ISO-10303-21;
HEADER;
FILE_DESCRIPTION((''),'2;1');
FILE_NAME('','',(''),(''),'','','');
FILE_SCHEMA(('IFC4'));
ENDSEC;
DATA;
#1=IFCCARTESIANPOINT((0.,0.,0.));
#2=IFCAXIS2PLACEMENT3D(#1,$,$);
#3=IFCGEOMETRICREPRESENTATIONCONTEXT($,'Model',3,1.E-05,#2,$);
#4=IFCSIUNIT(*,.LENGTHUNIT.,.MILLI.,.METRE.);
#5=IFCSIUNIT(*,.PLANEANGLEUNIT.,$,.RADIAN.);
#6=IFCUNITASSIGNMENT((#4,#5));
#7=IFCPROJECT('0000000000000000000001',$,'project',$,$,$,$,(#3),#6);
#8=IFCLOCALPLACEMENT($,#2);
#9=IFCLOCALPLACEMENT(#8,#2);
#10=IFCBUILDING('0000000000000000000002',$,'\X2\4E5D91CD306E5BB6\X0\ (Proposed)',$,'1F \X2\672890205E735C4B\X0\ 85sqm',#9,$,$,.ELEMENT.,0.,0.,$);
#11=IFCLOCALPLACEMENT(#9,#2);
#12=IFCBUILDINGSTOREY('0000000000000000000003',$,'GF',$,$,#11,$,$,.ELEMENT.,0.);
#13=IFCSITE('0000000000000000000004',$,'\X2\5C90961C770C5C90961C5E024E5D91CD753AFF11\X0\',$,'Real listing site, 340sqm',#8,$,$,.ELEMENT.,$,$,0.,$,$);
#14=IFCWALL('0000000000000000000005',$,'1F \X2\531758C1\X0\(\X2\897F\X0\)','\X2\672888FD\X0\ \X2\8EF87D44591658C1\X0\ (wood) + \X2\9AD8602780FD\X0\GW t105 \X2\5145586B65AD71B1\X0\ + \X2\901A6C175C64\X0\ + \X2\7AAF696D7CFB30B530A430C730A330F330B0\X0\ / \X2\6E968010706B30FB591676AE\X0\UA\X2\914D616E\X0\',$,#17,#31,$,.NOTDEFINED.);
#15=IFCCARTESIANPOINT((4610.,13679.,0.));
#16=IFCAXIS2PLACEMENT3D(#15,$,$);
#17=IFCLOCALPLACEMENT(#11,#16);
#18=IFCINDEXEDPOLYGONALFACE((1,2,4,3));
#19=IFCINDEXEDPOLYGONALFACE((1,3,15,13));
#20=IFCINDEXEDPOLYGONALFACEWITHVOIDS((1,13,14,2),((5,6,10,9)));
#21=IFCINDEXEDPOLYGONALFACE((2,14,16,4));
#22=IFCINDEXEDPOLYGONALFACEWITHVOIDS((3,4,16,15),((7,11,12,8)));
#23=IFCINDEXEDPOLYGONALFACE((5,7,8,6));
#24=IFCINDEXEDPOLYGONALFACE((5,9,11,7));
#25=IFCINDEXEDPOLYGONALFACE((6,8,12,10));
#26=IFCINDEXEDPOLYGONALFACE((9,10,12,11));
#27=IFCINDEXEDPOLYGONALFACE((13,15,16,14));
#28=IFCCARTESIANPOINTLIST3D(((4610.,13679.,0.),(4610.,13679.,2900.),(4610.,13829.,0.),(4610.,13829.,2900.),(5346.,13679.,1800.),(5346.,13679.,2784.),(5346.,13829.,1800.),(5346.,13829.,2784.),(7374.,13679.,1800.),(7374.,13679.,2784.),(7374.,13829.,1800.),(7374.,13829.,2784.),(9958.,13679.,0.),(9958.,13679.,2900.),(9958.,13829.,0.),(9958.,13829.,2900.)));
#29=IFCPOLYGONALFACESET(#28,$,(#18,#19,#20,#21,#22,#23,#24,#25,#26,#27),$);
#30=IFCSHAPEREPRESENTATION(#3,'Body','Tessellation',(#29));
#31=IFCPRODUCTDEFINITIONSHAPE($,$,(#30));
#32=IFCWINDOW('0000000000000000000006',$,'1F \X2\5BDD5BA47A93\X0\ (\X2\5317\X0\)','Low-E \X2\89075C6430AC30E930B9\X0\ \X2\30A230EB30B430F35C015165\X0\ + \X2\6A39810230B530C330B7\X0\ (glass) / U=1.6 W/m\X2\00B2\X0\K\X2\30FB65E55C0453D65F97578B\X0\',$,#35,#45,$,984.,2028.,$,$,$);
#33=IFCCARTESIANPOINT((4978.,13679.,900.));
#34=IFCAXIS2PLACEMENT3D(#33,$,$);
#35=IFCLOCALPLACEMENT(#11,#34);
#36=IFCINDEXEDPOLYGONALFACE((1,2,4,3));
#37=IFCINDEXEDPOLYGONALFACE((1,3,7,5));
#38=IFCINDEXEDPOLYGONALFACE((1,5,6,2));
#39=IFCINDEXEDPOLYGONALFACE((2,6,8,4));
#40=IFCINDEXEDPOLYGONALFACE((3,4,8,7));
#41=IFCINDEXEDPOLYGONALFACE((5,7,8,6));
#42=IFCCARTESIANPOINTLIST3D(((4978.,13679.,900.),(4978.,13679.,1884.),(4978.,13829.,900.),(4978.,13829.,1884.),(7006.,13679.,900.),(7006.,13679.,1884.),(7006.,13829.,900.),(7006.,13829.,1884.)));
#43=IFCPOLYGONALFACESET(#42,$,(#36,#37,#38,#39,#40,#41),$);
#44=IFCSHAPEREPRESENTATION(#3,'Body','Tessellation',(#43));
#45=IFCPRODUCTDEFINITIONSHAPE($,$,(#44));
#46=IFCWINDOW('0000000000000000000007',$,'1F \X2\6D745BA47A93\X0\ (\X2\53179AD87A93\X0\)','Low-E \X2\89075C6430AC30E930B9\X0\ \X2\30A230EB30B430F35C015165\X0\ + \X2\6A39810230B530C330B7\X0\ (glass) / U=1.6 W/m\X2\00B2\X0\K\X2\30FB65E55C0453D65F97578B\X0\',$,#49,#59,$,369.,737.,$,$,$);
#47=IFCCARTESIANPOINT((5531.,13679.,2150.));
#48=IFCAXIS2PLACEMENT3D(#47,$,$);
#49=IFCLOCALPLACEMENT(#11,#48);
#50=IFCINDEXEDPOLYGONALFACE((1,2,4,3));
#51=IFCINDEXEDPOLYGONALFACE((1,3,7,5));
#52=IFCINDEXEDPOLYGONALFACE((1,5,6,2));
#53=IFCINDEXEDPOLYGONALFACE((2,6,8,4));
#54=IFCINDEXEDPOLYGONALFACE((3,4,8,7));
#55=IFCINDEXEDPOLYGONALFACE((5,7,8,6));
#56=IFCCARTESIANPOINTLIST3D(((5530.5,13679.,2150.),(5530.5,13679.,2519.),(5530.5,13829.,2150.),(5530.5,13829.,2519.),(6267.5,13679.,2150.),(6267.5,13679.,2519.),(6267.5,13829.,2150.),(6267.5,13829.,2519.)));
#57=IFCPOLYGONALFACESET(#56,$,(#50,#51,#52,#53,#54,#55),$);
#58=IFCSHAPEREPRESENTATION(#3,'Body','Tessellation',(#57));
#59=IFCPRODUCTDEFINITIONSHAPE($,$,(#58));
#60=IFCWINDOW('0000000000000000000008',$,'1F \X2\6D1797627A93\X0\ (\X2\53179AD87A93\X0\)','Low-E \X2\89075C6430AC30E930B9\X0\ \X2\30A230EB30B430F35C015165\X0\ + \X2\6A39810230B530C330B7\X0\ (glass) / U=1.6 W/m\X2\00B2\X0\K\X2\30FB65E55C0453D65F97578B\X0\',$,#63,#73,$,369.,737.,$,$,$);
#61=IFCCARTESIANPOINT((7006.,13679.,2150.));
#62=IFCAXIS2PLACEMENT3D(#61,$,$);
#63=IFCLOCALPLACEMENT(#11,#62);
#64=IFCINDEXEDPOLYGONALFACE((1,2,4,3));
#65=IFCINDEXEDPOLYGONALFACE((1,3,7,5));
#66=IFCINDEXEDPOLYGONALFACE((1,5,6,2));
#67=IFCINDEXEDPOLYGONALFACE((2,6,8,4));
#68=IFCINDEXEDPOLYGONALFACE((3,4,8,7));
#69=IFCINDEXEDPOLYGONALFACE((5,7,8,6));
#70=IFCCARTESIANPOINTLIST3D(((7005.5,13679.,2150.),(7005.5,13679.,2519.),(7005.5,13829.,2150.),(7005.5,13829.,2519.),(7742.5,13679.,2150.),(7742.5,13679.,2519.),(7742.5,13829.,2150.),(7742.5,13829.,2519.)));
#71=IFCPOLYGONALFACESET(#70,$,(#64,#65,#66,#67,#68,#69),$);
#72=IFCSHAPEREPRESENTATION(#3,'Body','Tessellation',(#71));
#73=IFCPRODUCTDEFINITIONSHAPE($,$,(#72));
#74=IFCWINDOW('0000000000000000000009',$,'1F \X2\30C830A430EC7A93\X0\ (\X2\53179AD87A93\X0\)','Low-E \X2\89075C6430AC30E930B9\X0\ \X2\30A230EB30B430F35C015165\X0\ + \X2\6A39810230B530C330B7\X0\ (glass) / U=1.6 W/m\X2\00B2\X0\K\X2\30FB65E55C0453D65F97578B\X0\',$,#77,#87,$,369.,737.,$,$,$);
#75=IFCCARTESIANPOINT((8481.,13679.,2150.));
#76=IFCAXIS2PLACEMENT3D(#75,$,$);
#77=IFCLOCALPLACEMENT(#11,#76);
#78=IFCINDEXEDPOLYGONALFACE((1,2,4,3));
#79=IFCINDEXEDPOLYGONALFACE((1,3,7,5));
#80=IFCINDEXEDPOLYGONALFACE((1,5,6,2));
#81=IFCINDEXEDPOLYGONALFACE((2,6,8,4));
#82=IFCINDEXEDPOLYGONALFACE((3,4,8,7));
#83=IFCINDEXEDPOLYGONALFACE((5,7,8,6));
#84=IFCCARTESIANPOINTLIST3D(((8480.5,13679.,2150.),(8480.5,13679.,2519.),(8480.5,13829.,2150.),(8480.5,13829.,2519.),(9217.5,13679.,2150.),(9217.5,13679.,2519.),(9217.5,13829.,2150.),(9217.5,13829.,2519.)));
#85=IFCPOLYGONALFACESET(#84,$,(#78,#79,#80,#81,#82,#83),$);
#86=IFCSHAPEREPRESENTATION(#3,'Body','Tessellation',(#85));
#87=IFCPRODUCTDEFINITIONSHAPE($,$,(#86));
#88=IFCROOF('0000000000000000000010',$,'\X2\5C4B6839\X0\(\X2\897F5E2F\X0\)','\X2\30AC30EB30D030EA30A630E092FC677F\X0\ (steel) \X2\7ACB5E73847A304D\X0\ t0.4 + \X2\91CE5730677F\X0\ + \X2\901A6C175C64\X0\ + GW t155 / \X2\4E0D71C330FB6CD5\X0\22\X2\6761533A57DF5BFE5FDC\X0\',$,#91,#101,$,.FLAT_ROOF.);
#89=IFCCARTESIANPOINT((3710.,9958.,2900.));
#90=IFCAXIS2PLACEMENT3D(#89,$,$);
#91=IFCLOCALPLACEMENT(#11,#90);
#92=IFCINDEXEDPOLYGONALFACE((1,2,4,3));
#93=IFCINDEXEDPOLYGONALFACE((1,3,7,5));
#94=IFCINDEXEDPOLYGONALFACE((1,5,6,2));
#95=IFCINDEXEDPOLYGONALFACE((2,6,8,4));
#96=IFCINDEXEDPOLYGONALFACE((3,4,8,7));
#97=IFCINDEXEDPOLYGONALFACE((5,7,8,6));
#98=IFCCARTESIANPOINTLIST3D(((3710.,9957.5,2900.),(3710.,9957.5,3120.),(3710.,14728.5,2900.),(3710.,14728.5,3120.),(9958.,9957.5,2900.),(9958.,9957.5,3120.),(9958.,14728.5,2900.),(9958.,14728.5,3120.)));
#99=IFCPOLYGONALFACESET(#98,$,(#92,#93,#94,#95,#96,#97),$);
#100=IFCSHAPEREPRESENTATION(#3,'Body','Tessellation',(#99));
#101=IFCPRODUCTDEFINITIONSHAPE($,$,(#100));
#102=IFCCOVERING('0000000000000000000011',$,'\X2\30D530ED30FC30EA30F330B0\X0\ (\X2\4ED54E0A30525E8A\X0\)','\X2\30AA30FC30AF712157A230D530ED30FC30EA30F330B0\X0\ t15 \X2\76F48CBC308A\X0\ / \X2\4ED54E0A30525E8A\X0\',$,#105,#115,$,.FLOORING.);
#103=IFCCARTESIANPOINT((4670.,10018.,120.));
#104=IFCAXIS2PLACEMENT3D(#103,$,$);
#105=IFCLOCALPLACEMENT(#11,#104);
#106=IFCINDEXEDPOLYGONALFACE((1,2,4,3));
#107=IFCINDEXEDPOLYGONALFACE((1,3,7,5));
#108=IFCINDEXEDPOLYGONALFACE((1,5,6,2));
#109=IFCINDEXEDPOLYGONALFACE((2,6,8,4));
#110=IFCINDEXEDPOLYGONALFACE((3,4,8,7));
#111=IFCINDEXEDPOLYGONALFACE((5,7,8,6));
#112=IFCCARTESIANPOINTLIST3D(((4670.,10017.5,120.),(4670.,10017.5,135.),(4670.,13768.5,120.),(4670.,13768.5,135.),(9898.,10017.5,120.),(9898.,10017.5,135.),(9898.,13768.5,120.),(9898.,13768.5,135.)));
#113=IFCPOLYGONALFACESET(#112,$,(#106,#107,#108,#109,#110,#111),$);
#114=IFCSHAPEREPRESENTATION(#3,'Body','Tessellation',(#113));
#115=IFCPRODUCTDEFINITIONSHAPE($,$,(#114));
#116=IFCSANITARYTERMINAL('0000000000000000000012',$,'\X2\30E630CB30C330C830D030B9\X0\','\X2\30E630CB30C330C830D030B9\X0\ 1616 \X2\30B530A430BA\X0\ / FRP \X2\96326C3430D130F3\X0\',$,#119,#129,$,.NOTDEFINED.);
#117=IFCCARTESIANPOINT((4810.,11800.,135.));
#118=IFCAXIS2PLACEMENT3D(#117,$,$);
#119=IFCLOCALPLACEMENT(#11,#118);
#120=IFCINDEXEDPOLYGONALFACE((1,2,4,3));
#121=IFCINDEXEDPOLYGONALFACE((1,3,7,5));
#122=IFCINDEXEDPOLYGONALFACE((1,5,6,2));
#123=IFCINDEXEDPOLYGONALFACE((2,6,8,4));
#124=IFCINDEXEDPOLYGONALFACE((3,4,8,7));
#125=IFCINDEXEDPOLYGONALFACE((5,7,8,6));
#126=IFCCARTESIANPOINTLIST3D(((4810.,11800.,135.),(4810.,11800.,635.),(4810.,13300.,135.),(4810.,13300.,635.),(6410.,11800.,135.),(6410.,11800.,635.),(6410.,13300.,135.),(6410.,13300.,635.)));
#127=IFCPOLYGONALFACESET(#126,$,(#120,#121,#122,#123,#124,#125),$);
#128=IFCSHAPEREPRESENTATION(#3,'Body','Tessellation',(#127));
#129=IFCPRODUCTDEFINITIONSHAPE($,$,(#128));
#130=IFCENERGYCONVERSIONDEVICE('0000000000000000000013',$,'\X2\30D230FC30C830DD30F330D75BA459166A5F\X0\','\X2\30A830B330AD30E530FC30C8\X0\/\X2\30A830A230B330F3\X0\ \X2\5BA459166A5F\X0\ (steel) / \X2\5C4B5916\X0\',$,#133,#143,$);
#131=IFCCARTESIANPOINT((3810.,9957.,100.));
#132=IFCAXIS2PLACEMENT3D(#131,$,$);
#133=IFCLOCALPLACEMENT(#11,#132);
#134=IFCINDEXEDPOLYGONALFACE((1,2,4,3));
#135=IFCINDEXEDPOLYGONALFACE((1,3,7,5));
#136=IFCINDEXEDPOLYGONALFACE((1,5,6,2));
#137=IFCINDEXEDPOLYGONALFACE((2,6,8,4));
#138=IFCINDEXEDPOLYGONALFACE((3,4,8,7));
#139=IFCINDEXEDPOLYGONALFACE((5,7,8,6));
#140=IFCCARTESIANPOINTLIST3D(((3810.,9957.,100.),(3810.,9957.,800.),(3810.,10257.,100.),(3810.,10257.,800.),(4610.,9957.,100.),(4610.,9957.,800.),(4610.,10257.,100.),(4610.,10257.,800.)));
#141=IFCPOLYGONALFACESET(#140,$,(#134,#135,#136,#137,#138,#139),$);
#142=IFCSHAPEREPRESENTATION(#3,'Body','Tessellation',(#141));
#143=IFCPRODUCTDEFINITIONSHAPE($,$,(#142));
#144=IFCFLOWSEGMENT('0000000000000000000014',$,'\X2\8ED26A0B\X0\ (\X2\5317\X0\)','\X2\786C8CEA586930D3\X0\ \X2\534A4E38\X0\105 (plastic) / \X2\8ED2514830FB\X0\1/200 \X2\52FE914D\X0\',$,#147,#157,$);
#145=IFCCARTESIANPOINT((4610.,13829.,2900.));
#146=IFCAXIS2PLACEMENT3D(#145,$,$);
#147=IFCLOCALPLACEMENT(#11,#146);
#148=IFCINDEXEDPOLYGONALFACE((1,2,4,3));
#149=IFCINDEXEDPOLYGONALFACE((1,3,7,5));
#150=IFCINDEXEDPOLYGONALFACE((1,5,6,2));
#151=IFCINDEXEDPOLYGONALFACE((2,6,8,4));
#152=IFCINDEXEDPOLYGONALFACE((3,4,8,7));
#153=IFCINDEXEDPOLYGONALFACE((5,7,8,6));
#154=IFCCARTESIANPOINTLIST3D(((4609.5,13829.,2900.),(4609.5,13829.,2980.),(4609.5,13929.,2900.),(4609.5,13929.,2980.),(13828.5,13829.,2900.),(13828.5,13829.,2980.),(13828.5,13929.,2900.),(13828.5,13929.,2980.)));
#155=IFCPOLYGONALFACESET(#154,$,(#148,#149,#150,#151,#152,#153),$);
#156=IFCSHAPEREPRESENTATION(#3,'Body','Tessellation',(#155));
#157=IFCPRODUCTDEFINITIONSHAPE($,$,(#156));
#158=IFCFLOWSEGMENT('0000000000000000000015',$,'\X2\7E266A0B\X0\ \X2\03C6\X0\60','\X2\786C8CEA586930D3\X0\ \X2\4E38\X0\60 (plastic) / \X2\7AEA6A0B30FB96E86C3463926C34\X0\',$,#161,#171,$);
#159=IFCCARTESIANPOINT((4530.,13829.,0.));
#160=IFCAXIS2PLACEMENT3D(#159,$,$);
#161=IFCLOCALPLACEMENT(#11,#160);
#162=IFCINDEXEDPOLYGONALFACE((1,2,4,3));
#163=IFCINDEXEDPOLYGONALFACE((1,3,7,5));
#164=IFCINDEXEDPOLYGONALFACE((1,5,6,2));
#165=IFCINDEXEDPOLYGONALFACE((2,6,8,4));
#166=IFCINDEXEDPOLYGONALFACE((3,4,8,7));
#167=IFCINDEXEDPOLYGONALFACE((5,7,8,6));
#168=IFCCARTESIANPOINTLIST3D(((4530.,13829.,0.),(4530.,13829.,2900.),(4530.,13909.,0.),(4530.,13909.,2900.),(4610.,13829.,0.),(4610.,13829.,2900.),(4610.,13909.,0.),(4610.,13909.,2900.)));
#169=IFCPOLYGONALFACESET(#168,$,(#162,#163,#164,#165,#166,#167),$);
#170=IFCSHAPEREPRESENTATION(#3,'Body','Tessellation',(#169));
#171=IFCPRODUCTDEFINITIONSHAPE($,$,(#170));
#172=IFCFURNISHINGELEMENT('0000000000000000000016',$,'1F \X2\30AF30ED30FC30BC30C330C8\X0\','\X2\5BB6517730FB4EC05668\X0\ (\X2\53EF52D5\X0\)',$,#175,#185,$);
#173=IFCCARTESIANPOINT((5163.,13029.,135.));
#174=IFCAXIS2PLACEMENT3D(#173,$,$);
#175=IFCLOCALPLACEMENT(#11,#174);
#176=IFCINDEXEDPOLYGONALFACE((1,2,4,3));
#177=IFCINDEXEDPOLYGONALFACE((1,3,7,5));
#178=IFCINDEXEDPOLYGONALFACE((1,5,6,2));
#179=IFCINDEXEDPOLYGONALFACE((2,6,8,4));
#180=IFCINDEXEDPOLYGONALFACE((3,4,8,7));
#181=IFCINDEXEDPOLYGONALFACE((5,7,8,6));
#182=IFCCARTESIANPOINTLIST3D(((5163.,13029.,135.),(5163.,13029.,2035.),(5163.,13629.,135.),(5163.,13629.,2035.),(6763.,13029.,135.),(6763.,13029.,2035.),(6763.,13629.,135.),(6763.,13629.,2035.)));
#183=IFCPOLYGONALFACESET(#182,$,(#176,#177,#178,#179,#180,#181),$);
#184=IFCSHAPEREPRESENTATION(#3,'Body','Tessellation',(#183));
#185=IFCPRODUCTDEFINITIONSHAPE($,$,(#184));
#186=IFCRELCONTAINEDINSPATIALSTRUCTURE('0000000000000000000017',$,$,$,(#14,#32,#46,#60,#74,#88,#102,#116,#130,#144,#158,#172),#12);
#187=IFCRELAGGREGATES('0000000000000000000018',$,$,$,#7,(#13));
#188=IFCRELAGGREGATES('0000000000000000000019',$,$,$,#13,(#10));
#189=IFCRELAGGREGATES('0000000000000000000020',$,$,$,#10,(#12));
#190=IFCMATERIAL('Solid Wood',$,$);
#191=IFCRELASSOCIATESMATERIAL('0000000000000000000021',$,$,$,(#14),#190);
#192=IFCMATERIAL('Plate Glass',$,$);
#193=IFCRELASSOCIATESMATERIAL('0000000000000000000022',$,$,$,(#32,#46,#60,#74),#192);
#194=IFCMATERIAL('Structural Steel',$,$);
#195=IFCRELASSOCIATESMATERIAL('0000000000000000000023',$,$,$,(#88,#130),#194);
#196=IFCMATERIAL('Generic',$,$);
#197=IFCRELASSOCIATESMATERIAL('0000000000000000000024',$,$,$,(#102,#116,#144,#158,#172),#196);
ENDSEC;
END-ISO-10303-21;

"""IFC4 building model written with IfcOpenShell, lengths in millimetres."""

from ifc_helpers import new_model, si_unit, frame, frame_2d, origin, place, context, project, spatial, rectangle, extrude, material, element, fill, save


model = new_model("IFC4")

# Units and contexts
model_context = context("Model", 3, precision=1e-05, world=origin())
ifc_project = project(units=[si_unit("LENGTHUNIT", "METRE", prefix="MILLI"), si_unit("PLANEANGLEUNIT", "RADIAN")], contexts=[model_context])

# Site, building, storey
site_placement = place(None, origin())
site = spatial("IfcSite", under=ifc_project, at=site_placement, Name="岐阜県岐阜市九重町１", ObjectType="Real listing site, 340sqm", CompositionType="ELEMENT", RefElevation=0.0)
building_placement = place(site_placement, origin())
building = spatial("IfcBuilding", under=site, at=building_placement, Name="九重の家 (Proposed)", ObjectType="1F 木造平屋 85sqm", CompositionType="ELEMENT", ElevationOfRefHeight=0.0, ElevationOfTerrain=0.0)
storey_placement = place(building_placement, origin())
storey = spatial("IfcBuildingStorey", under=building, at=storey_placement, Name="GF", CompositionType="ELEMENT", Elevation=0.0)

# Shared definitions
ifc_material_1 = material(Name="Solid Wood")

# Wall, openings, windows
wall_1_placement = place(storey_placement, frame((4610.0, 13679.0, 0.0)))
wall_1 = element("IfcWall", 1, at=wall_1_placement, inside=storey, material=ifc_material_1, Name="1F 北壁(西)", Description="木製 軸組外壁 (wood) + 高性能GW t105 充填断熱 + 通気層 + 窯業系サイディング / 準耐火・外皮UA配慮", PredefinedType="NOTDEFINED", context=model_context, shape_type="SweptSolid", body=[
    extrude(rectangle(XDim=5348.0, YDim=150.0, at=frame_2d((2674.0, 75.0))), frame((4610.0, 13679.0, 0.0)), (0.0, 0.0, 1.0), 2900.0),
])
opening_1_placement = place(storey_placement, frame((4978.0, 13679.0, 900.0)))
opening_1 = element("IfcOpeningElement", 2, at=opening_1_placement, cuts=wall_1, PredefinedType="NOTDEFINED", context=model_context, shape_type="SweptSolid", body=[
    extrude(rectangle(XDim=2028.0, YDim=150.0, at=frame_2d((1014.0, 75.0))), frame((4978.0, 13679.0, 900.0)), (0.0, 0.0, 1.0), 984.0),
])
opening_2_placement = place(storey_placement, frame((5531.0, 13679.0, 2150.0)))
opening_2 = element("IfcOpeningElement", 3, at=opening_2_placement, cuts=wall_1, PredefinedType="NOTDEFINED", context=model_context, shape_type="SweptSolid", body=[
    extrude(rectangle(XDim=737.0, YDim=150.0, at=frame_2d((368.0, 75.0))), frame((5531.0, 13679.0, 2150.0)), (0.0, 0.0, 1.0), 369.0),
])
opening_3_placement = place(storey_placement, frame((7006.0, 13679.0, 2150.0)))
opening_3 = element("IfcOpeningElement", 4, at=opening_3_placement, cuts=wall_1, PredefinedType="NOTDEFINED", context=model_context, shape_type="SweptSolid", body=[
    extrude(rectangle(XDim=737.0, YDim=150.0, at=frame_2d((368.0, 75.0))), frame((7006.0, 13679.0, 2150.0)), (0.0, 0.0, 1.0), 369.0),
])
opening_4_placement = place(storey_placement, frame((8481.0, 13679.0, 2150.0)))
opening_4 = element("IfcOpeningElement", 5, at=opening_4_placement, cuts=wall_1, PredefinedType="NOTDEFINED", context=model_context, shape_type="SweptSolid", body=[
    extrude(rectangle(XDim=737.0, YDim=150.0, at=frame_2d((368.0, 75.0))), frame((8481.0, 13679.0, 2150.0)), (0.0, 0.0, 1.0), 369.0),
])
ifc_material_2 = material(Name="Plate Glass")
window_1_placement = place(storey_placement, frame((4978.0, 13679.0, 900.0)))
window_1 = element("IfcWindow", 6, at=window_1_placement, inside=storey, material=ifc_material_2, Name="1F 寝室窓 (北)", Description="Low-E 複層ガラス アルゴン封入 + 樹脂サッシ (glass) / U=1.6 W/m²K・日射取得型", OverallHeight=984.0, OverallWidth=2028.0, context=model_context, shape_type="SweptSolid", body=[
    extrude(rectangle(XDim=2028.0, YDim=150.0, at=frame_2d((1014.0, 75.0))), frame((4978.0, 13679.0, 900.0)), (0.0, 0.0, 1.0), 984.0),
])
fill(opening_1, window_1)
window_2_placement = place(storey_placement, frame((5531.0, 13679.0, 2150.0)))
window_2 = element("IfcWindow", 7, at=window_2_placement, inside=storey, material=ifc_material_2, Name="1F 浴室窓 (北高窓)", Description="Low-E 複層ガラス アルゴン封入 + 樹脂サッシ (glass) / U=1.6 W/m²K・日射取得型", OverallHeight=369.0, OverallWidth=737.0, context=model_context, shape_type="SweptSolid", body=[
    extrude(rectangle(XDim=737.0, YDim=150.0, at=frame_2d((368.0, 75.0))), frame((5531.0, 13679.0, 2150.0)), (0.0, 0.0, 1.0), 369.0),
])
fill(opening_2, window_2)
window_3_placement = place(storey_placement, frame((7006.0, 13679.0, 2150.0)))
window_3 = element("IfcWindow", 8, at=window_3_placement, inside=storey, material=ifc_material_2, Name="1F 洗面窓 (北高窓)", Description="Low-E 複層ガラス アルゴン封入 + 樹脂サッシ (glass) / U=1.6 W/m²K・日射取得型", OverallHeight=369.0, OverallWidth=737.0, context=model_context, shape_type="SweptSolid", body=[
    extrude(rectangle(XDim=737.0, YDim=150.0, at=frame_2d((368.0, 75.0))), frame((7006.0, 13679.0, 2150.0)), (0.0, 0.0, 1.0), 369.0),
])
fill(opening_3, window_3)
window_4_placement = place(storey_placement, frame((8481.0, 13679.0, 2150.0)))
window_4 = element("IfcWindow", 9, at=window_4_placement, inside=storey, material=ifc_material_2, Name="1F トイレ窓 (北高窓)", Description="Low-E 複層ガラス アルゴン封入 + 樹脂サッシ (glass) / U=1.6 W/m²K・日射取得型", OverallHeight=369.0, OverallWidth=737.0, context=model_context, shape_type="SweptSolid", body=[
    extrude(rectangle(XDim=737.0, YDim=150.0, at=frame_2d((368.0, 75.0))), frame((8481.0, 13679.0, 2150.0)), (0.0, 0.0, 1.0), 369.0),
])
fill(opening_4, window_4)

# Roof
ifc_material_3 = material(Name="Structural Steel")
roof_placement = place(storey_placement, frame((3710.0, 9958.0, 2900.0)))
element("IfcRoof", 10, at=roof_placement, inside=storey, material=ifc_material_3, Name="屋根(西帯)", Description="ガルバリウム鋼板 (steel) 立平葺き t0.4 + 野地板 + 通気層 + GW t155 / 不燃・法22条区域対応", PredefinedType="FLAT_ROOF", context=model_context, shape_type="SweptSolid", body=[
    extrude(rectangle(XDim=6248.0, YDim=4771.0, at=frame_2d((3124.0, 2385.0))), frame((3710.0, 9958.0, 2900.0)), (0.0, 0.0, 1.0), 220.0),
])

# Covering
ifc_material_4 = material(Name="Generic")
covering_placement = place(storey_placement, frame((4670.0, 10018.0, 120.0)))
element("IfcCovering", 11, at=covering_placement, inside=storey, material=ifc_material_4, Name="フローリング (仕上げ床)", Description="オーク無垢フローリング t15 直貼り / 仕上げ床", PredefinedType="FLOORING", context=model_context, shape_type="SweptSolid", body=[
    extrude(rectangle(XDim=5228.0, YDim=3751.0, at=frame_2d((2614.0, 1875.0))), frame((4670.0, 10018.0, 120.0)), (0.0, 0.0, 1.0), 15.0),
])

# Sanitary terminal
sanitary_terminal_placement = place(storey_placement, frame((4810.0, 11800.0, 135.0)))
element("IfcSanitaryTerminal", 12, at=sanitary_terminal_placement, inside=storey, material=ifc_material_4, Name="ユニットバス", Description="ユニットバス 1616 サイズ / FRP 防水パン", PredefinedType="NOTDEFINED", context=model_context, shape_type="SweptSolid", body=[
    extrude(rectangle(XDim=1600.0, YDim=1500.0, at=frame_2d((800.0, 750.0))), frame((4810.0, 11800.0, 135.0)), (0.0, 0.0, 1.0), 500.0),
])

# Energy conversion device
energy_conversion_device_placement = place(storey_placement, frame((3810.0, 9957.0, 100.0)))
element("IfcEnergyConversionDevice", 13, at=energy_conversion_device_placement, inside=storey, material=ifc_material_3, Name="ヒートポンプ室外機", Description="エコキュート/エアコン 室外機 (steel) / 屋外", context=model_context, shape_type="SweptSolid", body=[
    extrude(rectangle(XDim=800.0, YDim=300.0, at=frame_2d((400.0, 150.0))), frame((3810.0, 9957.0, 100.0)), (0.0, 0.0, 1.0), 700.0),
])

# Flow segments
flow_segment_1_placement = place(storey_placement, frame((4610.0, 13829.0, 2900.0)))
element("IfcFlowSegment", 14, at=flow_segment_1_placement, inside=storey, material=ifc_material_4, Name="軒樋 (北)", Description="硬質塩ビ 半丸105 (plastic) / 軒先・1/200 勾配", context=model_context, shape_type="SweptSolid", body=[
    extrude(rectangle(XDim=9219.0, YDim=100.0, at=frame_2d((4609.0, 50.0))), frame((4610.0, 13829.0, 2900.0)), (0.0, 0.0, 1.0), 80.0),
])
flow_segment_2_placement = place(storey_placement, frame((4530.0, 13829.0, 0.0)))
element("IfcFlowSegment", 15, at=flow_segment_2_placement, inside=storey, material=ifc_material_4, Name="縦樋 φ60", Description="硬質塩ビ 丸60 (plastic) / 竪樋・雨水排水", context=model_context, shape_type="SweptSolid", body=[
    extrude(rectangle(XDim=80.0, YDim=80.0, at=frame_2d((40.0, 40.0))), frame((4530.0, 13829.0, 0.0)), (0.0, 0.0, 1.0), 2900.0),
])

# Furnishing element
furnishing_1_placement = place(storey_placement, frame((5163.0, 13029.0, 135.0)))
element("IfcFurnishingElement", 16, at=furnishing_1_placement, inside=storey, material=ifc_material_4, Name="1F クローゼット", Description="家具・什器 (可動)", context=model_context, shape_type="SweptSolid", body=[
    extrude(rectangle(XDim=1600.0, YDim=600.0, at=frame_2d((800.0, 300.0))), frame((5163.0, 13029.0, 135.0)), (0.0, 0.0, 1.0), 1900.0),
])

save(model, "model.ifc")
